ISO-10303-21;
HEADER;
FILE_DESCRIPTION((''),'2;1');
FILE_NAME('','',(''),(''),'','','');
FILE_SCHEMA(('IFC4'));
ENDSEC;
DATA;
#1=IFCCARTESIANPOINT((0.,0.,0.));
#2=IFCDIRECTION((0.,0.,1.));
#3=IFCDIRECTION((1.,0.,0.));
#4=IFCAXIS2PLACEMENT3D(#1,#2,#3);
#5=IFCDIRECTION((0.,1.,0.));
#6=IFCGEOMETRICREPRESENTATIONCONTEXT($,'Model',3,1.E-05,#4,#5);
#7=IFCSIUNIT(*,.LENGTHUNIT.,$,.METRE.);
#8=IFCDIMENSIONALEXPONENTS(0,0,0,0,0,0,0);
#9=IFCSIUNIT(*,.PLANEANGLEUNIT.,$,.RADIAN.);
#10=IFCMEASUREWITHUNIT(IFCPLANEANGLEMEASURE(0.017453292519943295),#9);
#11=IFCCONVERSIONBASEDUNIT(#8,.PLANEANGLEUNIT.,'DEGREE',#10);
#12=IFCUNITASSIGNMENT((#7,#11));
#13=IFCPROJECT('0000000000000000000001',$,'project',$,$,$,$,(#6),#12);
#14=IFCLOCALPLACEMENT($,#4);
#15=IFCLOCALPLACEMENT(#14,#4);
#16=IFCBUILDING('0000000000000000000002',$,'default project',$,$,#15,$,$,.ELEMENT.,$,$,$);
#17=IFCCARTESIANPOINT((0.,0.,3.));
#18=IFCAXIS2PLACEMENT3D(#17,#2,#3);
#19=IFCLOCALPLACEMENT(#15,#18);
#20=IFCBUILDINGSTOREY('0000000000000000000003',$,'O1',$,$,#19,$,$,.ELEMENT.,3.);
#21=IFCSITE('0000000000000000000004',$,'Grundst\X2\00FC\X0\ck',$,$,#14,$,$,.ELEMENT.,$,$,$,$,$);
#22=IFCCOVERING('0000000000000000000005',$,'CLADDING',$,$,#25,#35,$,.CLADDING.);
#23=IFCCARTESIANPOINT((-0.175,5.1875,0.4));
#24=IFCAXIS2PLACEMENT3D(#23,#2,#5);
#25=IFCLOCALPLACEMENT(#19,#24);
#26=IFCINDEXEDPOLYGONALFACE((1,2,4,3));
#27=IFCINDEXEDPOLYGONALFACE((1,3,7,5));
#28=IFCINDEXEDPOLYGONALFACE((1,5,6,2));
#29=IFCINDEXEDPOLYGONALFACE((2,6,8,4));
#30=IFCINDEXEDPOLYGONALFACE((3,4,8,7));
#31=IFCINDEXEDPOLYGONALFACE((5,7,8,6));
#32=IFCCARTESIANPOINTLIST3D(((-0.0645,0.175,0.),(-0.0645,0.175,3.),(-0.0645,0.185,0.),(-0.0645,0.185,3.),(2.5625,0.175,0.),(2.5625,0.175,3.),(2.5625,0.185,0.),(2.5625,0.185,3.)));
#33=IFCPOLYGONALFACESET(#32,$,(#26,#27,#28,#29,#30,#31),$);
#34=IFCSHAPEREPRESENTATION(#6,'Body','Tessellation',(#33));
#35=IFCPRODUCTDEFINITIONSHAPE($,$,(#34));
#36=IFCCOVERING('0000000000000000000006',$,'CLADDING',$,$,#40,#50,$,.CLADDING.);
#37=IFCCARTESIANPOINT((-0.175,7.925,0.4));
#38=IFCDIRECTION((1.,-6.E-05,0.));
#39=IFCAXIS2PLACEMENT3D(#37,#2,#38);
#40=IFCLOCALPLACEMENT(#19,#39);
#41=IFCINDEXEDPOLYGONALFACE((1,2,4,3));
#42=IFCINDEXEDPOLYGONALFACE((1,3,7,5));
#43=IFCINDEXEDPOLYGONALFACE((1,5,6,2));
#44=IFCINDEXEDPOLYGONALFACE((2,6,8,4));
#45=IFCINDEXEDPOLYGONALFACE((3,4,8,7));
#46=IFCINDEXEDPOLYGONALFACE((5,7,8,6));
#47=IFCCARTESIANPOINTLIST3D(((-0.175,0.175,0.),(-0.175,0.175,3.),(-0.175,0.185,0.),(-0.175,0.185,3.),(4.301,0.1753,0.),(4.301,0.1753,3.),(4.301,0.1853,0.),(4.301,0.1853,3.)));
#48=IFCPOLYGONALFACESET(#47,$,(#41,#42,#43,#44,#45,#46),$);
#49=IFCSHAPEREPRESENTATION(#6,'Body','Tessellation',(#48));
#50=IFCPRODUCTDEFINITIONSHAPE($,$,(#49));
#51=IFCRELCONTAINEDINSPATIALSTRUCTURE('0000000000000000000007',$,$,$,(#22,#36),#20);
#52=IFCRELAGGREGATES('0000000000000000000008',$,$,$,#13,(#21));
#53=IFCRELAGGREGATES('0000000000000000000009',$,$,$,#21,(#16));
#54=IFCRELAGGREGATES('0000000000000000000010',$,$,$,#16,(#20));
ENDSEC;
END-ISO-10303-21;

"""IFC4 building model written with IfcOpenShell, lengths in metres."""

from ifc_helpers import new_model, entity, si_unit, converted_unit, direction, frame, origin_with_axes, place, context, project, spatial, polyline, outline, extrude, element, save


model = new_model("IFC4")

# Units and contexts
model_context = context("Model", 3, precision=1e-05, world=origin_with_axes(), true_north=direction((0.0, 1.0, 0.0)))
ifc_project = project(units=[si_unit("LENGTHUNIT", "METRE"), converted_unit("PLANEANGLEUNIT", "DEGREE", entity("IfcPlaneAngleMeasure", 0.017453292519943295), si_unit("PLANEANGLEUNIT", "RADIAN"), dimensions=[0, 0, 0, 0, 0, 0, 0])], contexts=[model_context])

# Site, building, storey
site_placement = place(None, origin_with_axes())
site = spatial("IfcSite", under=ifc_project, at=site_placement, Name="Grundstück", CompositionType="ELEMENT")
building_placement = place(site_placement, origin_with_axes())
building = spatial("IfcBuilding", under=site, at=building_placement, Name="default project", CompositionType="ELEMENT")
placement_1 = place(building_placement, frame((0.0, 0.0, 3.0), z_axis=(0.0, 0.0, 1.0), x_axis=(1.0, 0.0, 0.0)))
storey = spatial("IfcBuildingStorey", under=building, at=placement_1, Name="O1", CompositionType="ELEMENT", Elevation=3.0)

# Shared definitions
placement_2 = place(placement_1, frame((-0.175, 5.1875, 0.4), z_axis=(0.0, 0.0, 1.0), x_axis=(0.0, 1.0, 0.0)))
placement_3 = place(placement_1, frame((-0.175, 7.925, 0.4), z_axis=(0.0, 0.0, 1.0), x_axis=(1.0, -0.00006, 0.0)))

# Coverings
element("IfcCovering", 1, at=placement_2, inside=storey, Name="CLADDING", PredefinedType="CLADDING", context=model_context, shape_type="SweptSolid", body=[
    extrude(outline(polyline([(2.5625, 0.185), (-0.0645, 0.185), (-0.0645, 0.175), (2.5625, 0.175), (2.5625, 0.185)])), origin_with_axes(), (0.0, 0.0, 1.0), 3.0),
])
element("IfcCovering", 2, at=placement_3, inside=storey, Name="CLADDING", PredefinedType="CLADDING", context=model_context, shape_type="SweptSolid", body=[
    extrude(outline(polyline([(4.301, 0.1853), (-0.175, 0.185), (-0.175, 0.175), (4.301, 0.1753), (4.301, 0.1853)])), origin_with_axes(), (0.0, 0.0, 1.0), 3.0),
])

save(model, "model.ifc")
